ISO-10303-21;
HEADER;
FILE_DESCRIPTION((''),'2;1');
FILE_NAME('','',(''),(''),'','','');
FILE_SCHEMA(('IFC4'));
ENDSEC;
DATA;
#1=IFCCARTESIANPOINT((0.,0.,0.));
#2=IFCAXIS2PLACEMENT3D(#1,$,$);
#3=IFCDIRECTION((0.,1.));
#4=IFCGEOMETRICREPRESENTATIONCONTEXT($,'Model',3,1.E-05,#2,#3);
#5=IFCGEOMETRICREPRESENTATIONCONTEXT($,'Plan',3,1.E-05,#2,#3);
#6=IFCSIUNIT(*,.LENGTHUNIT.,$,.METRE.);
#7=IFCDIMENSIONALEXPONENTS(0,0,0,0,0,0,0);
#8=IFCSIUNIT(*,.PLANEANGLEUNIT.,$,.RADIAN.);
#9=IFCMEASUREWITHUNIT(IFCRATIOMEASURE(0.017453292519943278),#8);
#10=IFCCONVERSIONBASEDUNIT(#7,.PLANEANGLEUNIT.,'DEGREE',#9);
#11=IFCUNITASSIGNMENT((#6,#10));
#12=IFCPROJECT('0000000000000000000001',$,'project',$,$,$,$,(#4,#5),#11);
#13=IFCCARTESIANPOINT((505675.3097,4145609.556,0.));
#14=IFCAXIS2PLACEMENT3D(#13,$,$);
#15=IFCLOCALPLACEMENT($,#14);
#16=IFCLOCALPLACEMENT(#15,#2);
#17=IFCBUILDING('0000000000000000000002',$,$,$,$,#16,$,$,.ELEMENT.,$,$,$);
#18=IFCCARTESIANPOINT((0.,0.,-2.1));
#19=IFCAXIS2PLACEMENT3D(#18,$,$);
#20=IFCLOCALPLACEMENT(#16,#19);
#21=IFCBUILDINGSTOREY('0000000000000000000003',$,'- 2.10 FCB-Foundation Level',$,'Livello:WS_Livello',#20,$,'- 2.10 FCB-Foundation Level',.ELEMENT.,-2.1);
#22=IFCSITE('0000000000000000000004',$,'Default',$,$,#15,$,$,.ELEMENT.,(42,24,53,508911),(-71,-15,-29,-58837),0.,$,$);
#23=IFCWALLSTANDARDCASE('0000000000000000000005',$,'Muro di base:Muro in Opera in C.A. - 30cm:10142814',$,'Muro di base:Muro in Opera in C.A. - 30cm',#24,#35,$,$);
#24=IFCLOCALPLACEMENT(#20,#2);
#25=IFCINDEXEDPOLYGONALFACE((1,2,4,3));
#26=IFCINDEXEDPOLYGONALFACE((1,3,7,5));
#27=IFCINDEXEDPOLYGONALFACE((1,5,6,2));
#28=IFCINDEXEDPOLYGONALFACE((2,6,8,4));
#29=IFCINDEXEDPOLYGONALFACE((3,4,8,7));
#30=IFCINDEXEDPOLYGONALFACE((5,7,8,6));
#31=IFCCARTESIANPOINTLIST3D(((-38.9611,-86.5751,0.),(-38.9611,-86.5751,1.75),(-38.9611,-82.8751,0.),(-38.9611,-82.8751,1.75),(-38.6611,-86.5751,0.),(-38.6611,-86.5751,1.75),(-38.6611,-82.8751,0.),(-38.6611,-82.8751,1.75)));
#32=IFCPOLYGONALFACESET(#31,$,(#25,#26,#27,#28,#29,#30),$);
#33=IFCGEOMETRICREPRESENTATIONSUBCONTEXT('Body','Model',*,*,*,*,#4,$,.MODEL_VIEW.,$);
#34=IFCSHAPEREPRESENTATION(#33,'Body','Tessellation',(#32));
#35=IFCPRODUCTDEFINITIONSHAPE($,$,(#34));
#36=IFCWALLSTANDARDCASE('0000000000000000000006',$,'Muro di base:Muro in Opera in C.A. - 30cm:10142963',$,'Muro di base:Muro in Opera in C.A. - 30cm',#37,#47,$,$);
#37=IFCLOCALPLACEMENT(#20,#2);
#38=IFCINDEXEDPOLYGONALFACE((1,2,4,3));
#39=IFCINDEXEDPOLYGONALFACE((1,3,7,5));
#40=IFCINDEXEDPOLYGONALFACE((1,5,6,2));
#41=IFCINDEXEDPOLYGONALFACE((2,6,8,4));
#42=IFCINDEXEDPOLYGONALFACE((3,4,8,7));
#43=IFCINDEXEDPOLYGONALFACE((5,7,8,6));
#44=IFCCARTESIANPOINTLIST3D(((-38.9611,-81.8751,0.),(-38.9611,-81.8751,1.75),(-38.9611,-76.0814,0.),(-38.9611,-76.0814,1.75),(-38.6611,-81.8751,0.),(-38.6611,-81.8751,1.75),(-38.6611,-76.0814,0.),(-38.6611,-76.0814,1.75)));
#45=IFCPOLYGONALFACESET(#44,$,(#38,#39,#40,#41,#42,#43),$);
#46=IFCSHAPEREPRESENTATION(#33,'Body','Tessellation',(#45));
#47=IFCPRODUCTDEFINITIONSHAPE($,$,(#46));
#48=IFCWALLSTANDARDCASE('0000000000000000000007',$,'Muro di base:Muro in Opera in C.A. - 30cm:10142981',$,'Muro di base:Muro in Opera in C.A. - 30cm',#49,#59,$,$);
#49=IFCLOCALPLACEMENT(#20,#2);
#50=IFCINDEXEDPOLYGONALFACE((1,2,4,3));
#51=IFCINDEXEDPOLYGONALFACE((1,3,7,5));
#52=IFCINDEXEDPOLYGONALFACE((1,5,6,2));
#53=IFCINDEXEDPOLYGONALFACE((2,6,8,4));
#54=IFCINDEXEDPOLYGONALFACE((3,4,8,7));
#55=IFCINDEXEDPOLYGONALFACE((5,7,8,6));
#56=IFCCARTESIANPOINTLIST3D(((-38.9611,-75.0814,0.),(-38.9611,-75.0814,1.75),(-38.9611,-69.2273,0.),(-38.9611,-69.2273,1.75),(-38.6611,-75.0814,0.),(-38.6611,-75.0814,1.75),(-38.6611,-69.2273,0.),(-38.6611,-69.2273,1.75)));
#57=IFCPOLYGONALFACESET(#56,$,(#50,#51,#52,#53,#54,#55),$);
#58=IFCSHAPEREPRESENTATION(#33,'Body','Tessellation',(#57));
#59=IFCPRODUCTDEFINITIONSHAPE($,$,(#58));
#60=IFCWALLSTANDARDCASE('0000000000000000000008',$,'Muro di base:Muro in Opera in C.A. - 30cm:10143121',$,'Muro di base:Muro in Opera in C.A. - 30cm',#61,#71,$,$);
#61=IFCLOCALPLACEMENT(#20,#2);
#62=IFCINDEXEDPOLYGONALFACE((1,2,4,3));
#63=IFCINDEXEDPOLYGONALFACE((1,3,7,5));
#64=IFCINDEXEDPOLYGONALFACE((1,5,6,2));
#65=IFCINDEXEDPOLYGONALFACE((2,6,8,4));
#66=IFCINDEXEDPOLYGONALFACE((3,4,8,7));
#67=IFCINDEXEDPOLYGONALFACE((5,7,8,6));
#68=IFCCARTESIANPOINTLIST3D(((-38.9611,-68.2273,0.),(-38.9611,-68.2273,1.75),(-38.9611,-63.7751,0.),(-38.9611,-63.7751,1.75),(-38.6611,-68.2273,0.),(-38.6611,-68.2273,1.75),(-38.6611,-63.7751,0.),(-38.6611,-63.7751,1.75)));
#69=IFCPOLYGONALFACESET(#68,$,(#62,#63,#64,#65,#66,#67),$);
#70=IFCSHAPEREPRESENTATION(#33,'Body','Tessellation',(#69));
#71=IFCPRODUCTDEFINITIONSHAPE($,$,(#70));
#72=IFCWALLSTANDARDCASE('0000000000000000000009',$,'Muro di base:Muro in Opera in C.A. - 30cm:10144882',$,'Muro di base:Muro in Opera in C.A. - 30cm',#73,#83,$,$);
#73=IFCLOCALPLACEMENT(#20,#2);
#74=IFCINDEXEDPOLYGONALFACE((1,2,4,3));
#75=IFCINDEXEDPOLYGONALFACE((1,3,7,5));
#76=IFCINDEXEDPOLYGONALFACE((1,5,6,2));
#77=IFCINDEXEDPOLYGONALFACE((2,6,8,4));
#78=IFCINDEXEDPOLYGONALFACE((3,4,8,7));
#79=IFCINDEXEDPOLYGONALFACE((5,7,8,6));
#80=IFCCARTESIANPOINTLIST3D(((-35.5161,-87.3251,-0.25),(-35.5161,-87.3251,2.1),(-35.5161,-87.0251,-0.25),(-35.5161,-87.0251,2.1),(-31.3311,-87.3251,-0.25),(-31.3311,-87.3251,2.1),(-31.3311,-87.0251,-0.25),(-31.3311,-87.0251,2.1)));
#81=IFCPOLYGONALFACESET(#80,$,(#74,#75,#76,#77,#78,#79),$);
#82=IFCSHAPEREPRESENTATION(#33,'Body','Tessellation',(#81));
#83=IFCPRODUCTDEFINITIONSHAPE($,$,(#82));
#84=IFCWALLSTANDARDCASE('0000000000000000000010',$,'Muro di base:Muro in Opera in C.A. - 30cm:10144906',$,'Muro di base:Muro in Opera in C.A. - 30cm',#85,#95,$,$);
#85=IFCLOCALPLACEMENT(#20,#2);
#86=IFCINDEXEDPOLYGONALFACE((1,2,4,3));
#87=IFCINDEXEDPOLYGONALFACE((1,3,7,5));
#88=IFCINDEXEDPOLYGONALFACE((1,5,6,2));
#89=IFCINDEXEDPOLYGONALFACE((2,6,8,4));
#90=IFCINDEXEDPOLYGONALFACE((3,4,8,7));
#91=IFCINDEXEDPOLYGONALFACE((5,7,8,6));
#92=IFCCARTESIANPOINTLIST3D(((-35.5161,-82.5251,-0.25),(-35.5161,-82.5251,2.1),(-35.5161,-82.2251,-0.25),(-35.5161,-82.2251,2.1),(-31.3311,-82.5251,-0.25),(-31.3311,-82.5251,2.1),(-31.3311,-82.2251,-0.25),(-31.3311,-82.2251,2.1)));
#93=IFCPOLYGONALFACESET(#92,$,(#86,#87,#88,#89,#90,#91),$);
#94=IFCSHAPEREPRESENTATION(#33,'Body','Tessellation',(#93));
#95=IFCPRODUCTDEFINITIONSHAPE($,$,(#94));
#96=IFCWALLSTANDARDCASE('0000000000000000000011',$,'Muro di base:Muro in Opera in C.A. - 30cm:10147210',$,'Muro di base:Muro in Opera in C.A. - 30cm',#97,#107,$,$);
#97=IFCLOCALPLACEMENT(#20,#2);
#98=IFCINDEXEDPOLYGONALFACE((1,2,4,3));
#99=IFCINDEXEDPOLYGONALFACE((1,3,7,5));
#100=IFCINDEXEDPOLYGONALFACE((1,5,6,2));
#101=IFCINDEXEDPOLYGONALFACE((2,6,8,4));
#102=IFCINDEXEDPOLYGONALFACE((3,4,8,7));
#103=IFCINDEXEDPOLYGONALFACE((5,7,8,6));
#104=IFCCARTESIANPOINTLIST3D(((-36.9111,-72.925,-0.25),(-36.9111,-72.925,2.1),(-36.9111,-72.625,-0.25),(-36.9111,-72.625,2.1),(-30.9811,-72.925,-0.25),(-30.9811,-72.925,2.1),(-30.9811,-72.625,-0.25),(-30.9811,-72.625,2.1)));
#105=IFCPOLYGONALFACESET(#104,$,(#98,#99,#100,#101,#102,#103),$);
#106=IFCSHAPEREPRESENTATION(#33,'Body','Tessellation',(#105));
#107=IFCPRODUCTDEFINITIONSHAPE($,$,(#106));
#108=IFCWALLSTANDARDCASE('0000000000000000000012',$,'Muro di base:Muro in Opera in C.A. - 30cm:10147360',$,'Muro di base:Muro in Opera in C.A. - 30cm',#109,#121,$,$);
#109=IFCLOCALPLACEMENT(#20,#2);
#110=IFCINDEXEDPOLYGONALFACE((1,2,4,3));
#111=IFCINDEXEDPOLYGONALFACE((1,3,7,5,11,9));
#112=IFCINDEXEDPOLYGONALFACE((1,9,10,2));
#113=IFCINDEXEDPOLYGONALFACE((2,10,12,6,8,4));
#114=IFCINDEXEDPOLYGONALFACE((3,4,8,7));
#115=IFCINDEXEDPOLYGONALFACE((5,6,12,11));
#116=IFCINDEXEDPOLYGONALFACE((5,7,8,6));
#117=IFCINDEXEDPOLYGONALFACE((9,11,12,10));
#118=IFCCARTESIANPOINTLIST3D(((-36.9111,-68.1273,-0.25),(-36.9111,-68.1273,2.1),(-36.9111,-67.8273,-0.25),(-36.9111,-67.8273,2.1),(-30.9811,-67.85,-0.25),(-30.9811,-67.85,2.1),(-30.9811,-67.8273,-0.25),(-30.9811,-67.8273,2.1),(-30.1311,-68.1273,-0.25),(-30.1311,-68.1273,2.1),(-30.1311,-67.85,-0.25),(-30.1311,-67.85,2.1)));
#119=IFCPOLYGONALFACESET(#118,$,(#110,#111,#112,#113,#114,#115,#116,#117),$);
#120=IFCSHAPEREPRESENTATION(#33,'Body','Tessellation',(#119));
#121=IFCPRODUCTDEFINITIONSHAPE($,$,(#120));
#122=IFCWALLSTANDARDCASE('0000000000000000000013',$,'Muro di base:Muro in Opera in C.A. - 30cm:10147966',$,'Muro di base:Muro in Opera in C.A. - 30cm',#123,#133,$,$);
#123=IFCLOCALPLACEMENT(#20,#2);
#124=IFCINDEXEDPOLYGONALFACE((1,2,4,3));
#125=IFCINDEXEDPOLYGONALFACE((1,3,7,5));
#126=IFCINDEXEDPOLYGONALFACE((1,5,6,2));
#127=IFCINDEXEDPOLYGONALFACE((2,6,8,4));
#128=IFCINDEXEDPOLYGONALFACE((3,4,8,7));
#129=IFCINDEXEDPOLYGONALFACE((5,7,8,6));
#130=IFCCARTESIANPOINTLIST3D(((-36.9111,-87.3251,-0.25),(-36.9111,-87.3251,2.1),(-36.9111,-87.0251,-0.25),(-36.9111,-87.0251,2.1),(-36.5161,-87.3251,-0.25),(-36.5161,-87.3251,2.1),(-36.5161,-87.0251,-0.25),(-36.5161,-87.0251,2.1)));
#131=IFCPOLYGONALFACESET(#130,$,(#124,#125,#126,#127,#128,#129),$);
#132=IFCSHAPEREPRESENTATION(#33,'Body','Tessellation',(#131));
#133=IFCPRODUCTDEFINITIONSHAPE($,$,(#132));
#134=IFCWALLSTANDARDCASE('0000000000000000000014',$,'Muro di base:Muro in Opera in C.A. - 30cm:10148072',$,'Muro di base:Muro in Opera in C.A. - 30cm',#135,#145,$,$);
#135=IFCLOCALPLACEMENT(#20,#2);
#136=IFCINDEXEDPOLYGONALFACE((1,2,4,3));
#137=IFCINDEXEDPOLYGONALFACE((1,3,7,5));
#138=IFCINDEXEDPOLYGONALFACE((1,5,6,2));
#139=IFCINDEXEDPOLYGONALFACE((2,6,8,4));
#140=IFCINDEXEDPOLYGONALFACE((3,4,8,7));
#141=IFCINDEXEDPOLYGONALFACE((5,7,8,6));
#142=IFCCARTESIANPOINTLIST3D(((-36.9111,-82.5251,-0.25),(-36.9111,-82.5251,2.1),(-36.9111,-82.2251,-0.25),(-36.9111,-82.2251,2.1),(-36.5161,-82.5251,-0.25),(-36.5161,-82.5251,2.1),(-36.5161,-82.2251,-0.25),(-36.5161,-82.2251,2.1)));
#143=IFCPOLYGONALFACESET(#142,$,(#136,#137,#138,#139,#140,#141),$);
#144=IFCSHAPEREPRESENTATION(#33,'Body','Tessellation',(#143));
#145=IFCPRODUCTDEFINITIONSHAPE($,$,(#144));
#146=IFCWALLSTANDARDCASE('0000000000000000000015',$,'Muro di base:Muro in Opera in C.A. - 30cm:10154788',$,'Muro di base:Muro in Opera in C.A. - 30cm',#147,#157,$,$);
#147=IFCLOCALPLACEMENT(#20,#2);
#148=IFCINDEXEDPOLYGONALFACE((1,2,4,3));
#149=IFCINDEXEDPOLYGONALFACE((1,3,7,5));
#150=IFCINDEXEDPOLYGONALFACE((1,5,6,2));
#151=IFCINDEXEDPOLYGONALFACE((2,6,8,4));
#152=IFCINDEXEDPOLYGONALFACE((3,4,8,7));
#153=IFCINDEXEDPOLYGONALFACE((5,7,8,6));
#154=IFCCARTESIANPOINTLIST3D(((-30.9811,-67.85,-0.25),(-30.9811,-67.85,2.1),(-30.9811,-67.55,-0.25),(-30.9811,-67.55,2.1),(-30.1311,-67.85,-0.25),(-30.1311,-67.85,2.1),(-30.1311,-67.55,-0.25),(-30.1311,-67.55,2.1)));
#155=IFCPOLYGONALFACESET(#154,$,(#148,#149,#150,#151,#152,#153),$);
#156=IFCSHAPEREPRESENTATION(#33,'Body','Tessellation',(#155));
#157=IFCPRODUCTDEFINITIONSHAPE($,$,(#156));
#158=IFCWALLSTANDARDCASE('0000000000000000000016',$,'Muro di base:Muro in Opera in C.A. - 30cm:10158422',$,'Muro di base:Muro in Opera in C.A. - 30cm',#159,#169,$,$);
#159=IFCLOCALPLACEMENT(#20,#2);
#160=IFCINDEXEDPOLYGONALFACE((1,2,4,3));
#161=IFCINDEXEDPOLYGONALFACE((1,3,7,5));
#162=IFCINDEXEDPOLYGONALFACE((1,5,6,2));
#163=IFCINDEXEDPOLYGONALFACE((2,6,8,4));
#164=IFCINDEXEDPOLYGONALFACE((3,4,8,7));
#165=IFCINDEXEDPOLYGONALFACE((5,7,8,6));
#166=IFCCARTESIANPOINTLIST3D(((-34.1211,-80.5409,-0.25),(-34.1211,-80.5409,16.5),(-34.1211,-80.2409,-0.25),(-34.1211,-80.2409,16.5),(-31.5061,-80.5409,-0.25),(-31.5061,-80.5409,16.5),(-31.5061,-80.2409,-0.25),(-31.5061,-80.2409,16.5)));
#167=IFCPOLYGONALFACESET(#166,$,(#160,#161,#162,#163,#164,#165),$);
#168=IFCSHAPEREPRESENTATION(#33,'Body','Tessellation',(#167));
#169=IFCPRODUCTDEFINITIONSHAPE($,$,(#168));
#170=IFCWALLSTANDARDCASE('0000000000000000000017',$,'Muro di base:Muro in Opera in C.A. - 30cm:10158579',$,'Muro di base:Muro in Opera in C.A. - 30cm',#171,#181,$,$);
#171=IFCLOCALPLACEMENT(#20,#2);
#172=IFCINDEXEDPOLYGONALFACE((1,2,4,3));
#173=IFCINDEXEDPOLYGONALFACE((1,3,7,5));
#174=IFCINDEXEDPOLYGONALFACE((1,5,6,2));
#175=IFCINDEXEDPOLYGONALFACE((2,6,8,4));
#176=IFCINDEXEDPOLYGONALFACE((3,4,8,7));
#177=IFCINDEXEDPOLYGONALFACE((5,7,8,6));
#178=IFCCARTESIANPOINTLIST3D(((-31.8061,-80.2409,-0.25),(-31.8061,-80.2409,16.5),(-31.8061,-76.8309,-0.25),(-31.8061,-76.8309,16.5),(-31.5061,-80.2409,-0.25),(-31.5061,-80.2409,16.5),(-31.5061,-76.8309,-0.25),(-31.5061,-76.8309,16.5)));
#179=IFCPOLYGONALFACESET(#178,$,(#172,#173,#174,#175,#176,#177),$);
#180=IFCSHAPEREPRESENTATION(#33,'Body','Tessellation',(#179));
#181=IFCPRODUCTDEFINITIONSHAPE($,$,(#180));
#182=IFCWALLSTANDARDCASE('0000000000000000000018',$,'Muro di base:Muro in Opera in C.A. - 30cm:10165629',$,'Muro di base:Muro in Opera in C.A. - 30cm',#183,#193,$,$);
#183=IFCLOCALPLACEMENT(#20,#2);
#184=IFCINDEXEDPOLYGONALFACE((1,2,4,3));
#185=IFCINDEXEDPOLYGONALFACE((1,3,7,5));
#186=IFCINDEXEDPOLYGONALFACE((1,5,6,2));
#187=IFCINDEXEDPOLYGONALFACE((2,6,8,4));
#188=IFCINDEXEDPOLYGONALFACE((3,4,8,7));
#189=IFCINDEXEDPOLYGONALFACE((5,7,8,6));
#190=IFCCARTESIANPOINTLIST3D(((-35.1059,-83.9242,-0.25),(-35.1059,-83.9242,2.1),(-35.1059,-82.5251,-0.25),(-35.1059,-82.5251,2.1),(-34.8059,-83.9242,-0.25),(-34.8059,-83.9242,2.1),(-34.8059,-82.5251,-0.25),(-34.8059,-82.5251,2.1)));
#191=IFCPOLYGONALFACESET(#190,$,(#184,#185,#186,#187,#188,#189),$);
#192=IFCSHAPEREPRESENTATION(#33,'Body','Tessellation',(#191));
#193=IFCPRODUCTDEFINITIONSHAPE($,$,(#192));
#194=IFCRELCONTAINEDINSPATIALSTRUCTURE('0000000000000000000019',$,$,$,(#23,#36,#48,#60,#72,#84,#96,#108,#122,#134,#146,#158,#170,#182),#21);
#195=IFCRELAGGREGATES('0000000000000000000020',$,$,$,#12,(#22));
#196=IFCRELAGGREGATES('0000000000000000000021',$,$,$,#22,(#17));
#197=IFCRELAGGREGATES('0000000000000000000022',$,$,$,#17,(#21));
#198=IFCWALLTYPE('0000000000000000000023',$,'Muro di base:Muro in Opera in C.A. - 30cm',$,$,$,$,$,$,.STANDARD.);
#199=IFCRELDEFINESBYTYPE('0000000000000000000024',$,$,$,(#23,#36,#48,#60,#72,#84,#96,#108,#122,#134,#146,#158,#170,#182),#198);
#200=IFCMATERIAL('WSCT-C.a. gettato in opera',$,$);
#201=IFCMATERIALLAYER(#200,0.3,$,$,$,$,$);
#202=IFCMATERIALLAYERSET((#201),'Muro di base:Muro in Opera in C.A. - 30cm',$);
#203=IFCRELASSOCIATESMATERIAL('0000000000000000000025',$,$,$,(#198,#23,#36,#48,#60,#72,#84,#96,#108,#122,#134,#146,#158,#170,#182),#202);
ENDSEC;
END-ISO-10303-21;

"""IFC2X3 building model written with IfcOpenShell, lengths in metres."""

from ifc_helpers import new_model, entity, si_unit, converted_unit, direction, frame, frame_2d, origin, place, context, subcontext, project, spatial, polyline, rectangle, extrude, clip, bounded_halfspace, material, layer, layer_set, layer_usage, type_object, element, save


model = new_model("IFC2X3")

# Units and contexts
model_context = context("Model", 3, precision=1e-05, world=origin(), true_north=direction((0.0, 1.0)))
plan_context = context("Plan", 3, precision=1e-05, world=origin(), true_north=direction((0.0, 1.0)))
body_context = subcontext(model_context, "Body", "Model", "MODEL_VIEW")
ifc_project = project(units=[si_unit("LENGTHUNIT", "METRE"), converted_unit("PLANEANGLEUNIT", "DEGREE", entity("IfcRatioMeasure", 0.017453292519943278), si_unit("PLANEANGLEUNIT", "RADIAN"), dimensions=[0, 0, 0, 0, 0, 0, 0])], contexts=[model_context, plan_context])

# Site, building, storey
site_placement = place(None, frame((505675.3097, 4145609.556, 0.0)))
site = spatial("IfcSite", under=ifc_project, at=site_placement, Name="Default", CompositionType="ELEMENT", RefLatitude=(42, 24, 53, 508911), RefLongitude=(-71, -15, -29, -58837), RefElevation=0.0)
building_placement = place(site_placement, origin())
building = spatial("IfcBuilding", under=site, at=building_placement, CompositionType="ELEMENT")
storey_placement = place(building_placement, frame((0.0, 0.0, -2.1)))
storey = spatial("IfcBuildingStorey", under=building, at=storey_placement, Name="- 2.10 FCB-Foundation Level", ObjectType="Livello:WS_Livello", LongName="- 2.10 FCB-Foundation Level", CompositionType="ELEMENT", Elevation=-2.1)

# Walls
ifc_material = material(Name="WSCT-C.a. gettato in opera")
ifc_layer_1 = layer(ifc_material, 0.3)
ifc_layer_set_1 = layer_set([ifc_layer_1], Name="Muro di base:Muro in Opera in C.A. - 30cm")
ifc_layer_usage_1 = layer_usage(ifc_layer_set_1, "AXIS2", "NEGATIVE", 0.15)
wall_type_1 = type_object("IfcWallType", Name="Muro di base:Muro in Opera in C.A. - 30cm", PredefinedType="STANDARD", material=ifc_layer_set_1)
wall_1_placement = place(storey_placement, frame((-38.8111, -86.5751, 0.0), z_axis=(0.0, 0.0, 1.0), x_axis=(0.0, 1.0, 0.0)))
element("IfcWallStandardCase", 1, at=wall_1_placement, inside=storey, type_object=wall_type_1, material=ifc_layer_usage_1, Name="Muro di base:Muro in Opera in C.A. - 30cm:10142814", ObjectType="Muro di base:Muro in Opera in C.A. - 30cm", context=body_context, shape_type="SweptSolid", body=[
    extrude(rectangle(XDim=3.7, YDim=0.3, at=frame_2d((1.85, 0.0), x_axis=(-1.0, 0.0))), origin(), (0.0, 0.0, 1.0), 1.75),
])
wall_2_placement = place(storey_placement, frame((-38.8111, -81.8751, 0.0), z_axis=(0.0, 0.0, 1.0), x_axis=(0.0, 1.0, 0.0)))
element("IfcWallStandardCase", 2, at=wall_2_placement, inside=storey, type_object=wall_type_1, material=ifc_layer_usage_1, Name="Muro di base:Muro in Opera in C.A. - 30cm:10142963", ObjectType="Muro di base:Muro in Opera in C.A. - 30cm", context=body_context, shape_type="SweptSolid", body=[
    extrude(rectangle(XDim=5.7938, YDim=0.3, at=frame_2d((2.8969, 0.0), x_axis=(-1.0, 0.0))), origin(), (0.0, 0.0, 1.0), 1.75),
])
wall_3_placement = place(storey_placement, frame((-38.8111, -75.0814, 0.0), z_axis=(0.0, 0.0, 1.0), x_axis=(0.0, 1.0, 0.0)))
element("IfcWallStandardCase", 3, at=wall_3_placement, inside=storey, type_object=wall_type_1, material=ifc_layer_usage_1, Name="Muro di base:Muro in Opera in C.A. - 30cm:10142981", ObjectType="Muro di base:Muro in Opera in C.A. - 30cm", context=body_context, shape_type="SweptSolid", body=[
    extrude(rectangle(XDim=5.854, YDim=0.3, at=frame_2d((2.927, 0.0), x_axis=(-1.0, 0.0))), origin(), (0.0, 0.0, 1.0), 1.75),
])
wall_4_placement = place(storey_placement, frame((-38.8111, -68.2273, 0.0), z_axis=(0.0, 0.0, 1.0), x_axis=(0.0, 1.0, 0.0)))
element("IfcWallStandardCase", 4, at=wall_4_placement, inside=storey, type_object=wall_type_1, material=ifc_layer_usage_1, Name="Muro di base:Muro in Opera in C.A. - 30cm:10143121", ObjectType="Muro di base:Muro in Opera in C.A. - 30cm", context=body_context, shape_type="SweptSolid", body=[
    extrude(rectangle(XDim=4.4522, YDim=0.3, at=frame_2d((2.2261, 0.0), x_axis=(-1.0, 0.0))), origin(), (0.0, 0.0, 1.0), 1.75),
])
for number, where, name in (
    (5, (-35.5161, -87.1751, -0.25), "Muro di base:Muro in Opera in C.A. - 30cm:10144882"),
    (6, (-35.5161, -82.3751, -0.25), "Muro di base:Muro in Opera in C.A. - 30cm:10144906"),
):
    element("IfcWallStandardCase", number, at=place(storey_placement, frame(where)), inside=storey, type_object=wall_type_1, material=ifc_layer_usage_1, Name=name, ObjectType="Muro di base:Muro in Opera in C.A. - 30cm", context=body_context, shape_type="SweptSolid", body=[
        extrude(rectangle(XDim=4.1851, YDim=0.3, at=frame_2d((2.0925, 0.0), x_axis=(-1.0, 0.0))), origin(), (0.0, 0.0, 1.0), 2.35),
    ])
wall_5_placement = place(storey_placement, frame((-36.9111, -72.775, -0.25)))
element("IfcWallStandardCase", 7, at=wall_5_placement, inside=storey, type_object=wall_type_1, material=ifc_layer_usage_1, Name="Muro di base:Muro in Opera in C.A. - 30cm:10147210", ObjectType="Muro di base:Muro in Opera in C.A. - 30cm", context=body_context, shape_type="SweptSolid", body=[
    extrude(rectangle(XDim=5.93, YDim=0.3, at=frame_2d((2.965, 0.0), x_axis=(-1.0, 0.0))), origin(), (0.0, 0.0, 1.0), 2.35),
])
wall_6_placement = place(storey_placement, frame((-36.9111, -67.9773, -0.25)))
element("IfcWallStandardCase", 8, at=wall_6_placement, inside=storey, type_object=wall_type_1, material=ifc_layer_usage_1, Name="Muro di base:Muro in Opera in C.A. - 30cm:10147360", ObjectType="Muro di base:Muro in Opera in C.A. - 30cm", context=body_context, shape_type="Clipping", body=[
    clip(clip(extrude(rectangle(XDim=6.78, YDim=0.3, at=frame_2d((3.39, 0.0), x_axis=(-1.0, 0.0))), origin(), (0.0, 0.0, 1.0), 2.35), bounded_halfspace(frame((5.93, 0.1273, 0.0), z_axis=(0.0, -1.0, 0.0), x_axis=(1.0, 0.0, 0.0)), True, frame((5.93, 0.1273, 0.0), z_axis=(0.0, -1.0, 0.0), x_axis=(1.0, 0.0, 0.0)), polyline([(0.0, 0.0), (0.85, 0.0), (0.85, 2.35), (0.0, 2.35), (0.0, 0.0)]))), bounded_halfspace(frame((5.93, 0.1273, 2.35), z_axis=(-1.0, 0.0, 0.0), x_axis=(0.0, 1.0, 0.0)), True, frame((5.93, 0.1273, 2.35), z_axis=(-1.0, 0.0, 0.0), x_axis=(0.0, 1.0, 0.0)), polyline([(0.0, 0.0), (0.0227, 0.0), (0.0227, 2.35), (0.0, 2.35), (0.0, 0.0)]))),
])
wall_7_placement = place(storey_placement, frame((-36.5161, -87.1751, -0.25), z_axis=(0.0, 0.0, 1.0), x_axis=(-1.0, 0.0, 0.0)))
element("IfcWallStandardCase", 9, at=wall_7_placement, inside=storey, type_object=wall_type_1, material=ifc_layer_usage_1, Name="Muro di base:Muro in Opera in C.A. - 30cm:10147966", ObjectType="Muro di base:Muro in Opera in C.A. - 30cm", context=body_context, shape_type="SweptSolid", body=[
    extrude(rectangle(XDim=0.3949, YDim=0.3, at=frame_2d((0.1975, 0.0), x_axis=(-1.0, 0.0))), origin(), (0.0, 0.0, 1.0), 2.35),
])
wall_8_placement = place(storey_placement, frame((-36.5161, -82.3751, -0.25), z_axis=(0.0, 0.0, 1.0), x_axis=(-1.0, 0.0, 0.0)))
element("IfcWallStandardCase", 10, at=wall_8_placement, inside=storey, type_object=wall_type_1, material=ifc_layer_usage_1, Name="Muro di base:Muro in Opera in C.A. - 30cm:10148072", ObjectType="Muro di base:Muro in Opera in C.A. - 30cm", context=body_context, shape_type="SweptSolid", body=[
    extrude(rectangle(XDim=0.3949, YDim=0.3, at=frame_2d((0.1975, 0.0), x_axis=(-1.0, 0.0))), origin(), (0.0, 0.0, 1.0), 2.35),
])
wall_9_placement = place(storey_placement, frame((-30.9811, -67.7, -0.25)))
element("IfcWallStandardCase", 11, at=wall_9_placement, inside=storey, type_object=wall_type_1, material=ifc_layer_usage_1, Name="Muro di base:Muro in Opera in C.A. - 30cm:10154788", ObjectType="Muro di base:Muro in Opera in C.A. - 30cm", context=body_context, shape_type="SweptSolid", body=[
    extrude(rectangle(XDim=0.85, YDim=0.3, at=frame_2d((0.425, 0.0), x_axis=(-1.0, 0.0))), origin(), (0.0, 0.0, 1.0), 2.35),
])
wall_10_placement = place(storey_placement, frame((-34.1211, -80.3909, -0.25)))
element("IfcWallStandardCase", 12, at=wall_10_placement, inside=storey, type_object=wall_type_1, material=ifc_layer_usage_1, Name="Muro di base:Muro in Opera in C.A. - 30cm:10158422", ObjectType="Muro di base:Muro in Opera in C.A. - 30cm", context=body_context, shape_type="Clipping", body=[
    clip(extrude(rectangle(XDim=2.615, YDim=0.3, at=frame_2d((1.3075, 0.0), x_axis=(-1.0, 0.0))), origin(), (0.0, 0.0, 1.0), 16.75), bounded_halfspace(frame((0.0, -0.15, 16.75), z_axis=(0.0, 0.0, -1.0), x_axis=(0.0, -1.0, 0.0)), True, frame((0.0, -0.15, 16.75)), polyline([(0.0, 0.0), (2.615, 0.0), (2.615, 0.3), (2.315, 0.3), (0.0, 0.3), (0.0, 0.0)]))),
])
wall_11_placement = place(storey_placement, frame((-31.6561, -80.2409, -0.25), z_axis=(0.0, 0.0, 1.0), x_axis=(0.0, 1.0, 0.0)))
element("IfcWallStandardCase", 13, at=wall_11_placement, inside=storey, type_object=wall_type_1, material=ifc_layer_usage_1, Name="Muro di base:Muro in Opera in C.A. - 30cm:10158579", ObjectType="Muro di base:Muro in Opera in C.A. - 30cm", context=body_context, shape_type="Clipping", body=[
    clip(extrude(rectangle(XDim=3.41, YDim=0.3, at=frame_2d((1.705, 0.0), x_axis=(-1.0, 0.0))), origin(), (0.0, 0.0, 1.0), 16.75), bounded_halfspace(frame((0.0, -0.15, 16.75), z_axis=(0.0, 0.0, -1.0), x_axis=(-1.0, 0.0, 0.0)), True, frame((0.0, -0.15, 16.75)), polyline([(0.0, 0.0), (3.405, 0.0), (3.405, 0.3), (3.11, 0.3), (0.0, 0.3), (0.0, 0.0)]))),
])

# Wall
wall_12_placement = place(storey_placement, frame((-34.9559, -83.9242, -0.25), z_axis=(0.0, 0.0, 1.0), x_axis=(0.0, 1.0, 0.0)))
element("IfcWallStandardCase", 14, at=wall_12_placement, inside=storey, type_object=wall_type_1, material=ifc_layer_usage_1, Name="Muro di base:Muro in Opera in C.A. - 30cm:10165629", ObjectType="Muro di base:Muro in Opera in C.A. - 30cm", context=body_context, shape_type="SweptSolid", body=[
    extrude(rectangle(XDim=1.399, YDim=0.3, at=frame_2d((0.6995, 0.0), x_axis=(-1.0, 0.0))), origin(), (0.0, 0.0, 1.0), 2.35),
])

save(model, "model.ifc")
